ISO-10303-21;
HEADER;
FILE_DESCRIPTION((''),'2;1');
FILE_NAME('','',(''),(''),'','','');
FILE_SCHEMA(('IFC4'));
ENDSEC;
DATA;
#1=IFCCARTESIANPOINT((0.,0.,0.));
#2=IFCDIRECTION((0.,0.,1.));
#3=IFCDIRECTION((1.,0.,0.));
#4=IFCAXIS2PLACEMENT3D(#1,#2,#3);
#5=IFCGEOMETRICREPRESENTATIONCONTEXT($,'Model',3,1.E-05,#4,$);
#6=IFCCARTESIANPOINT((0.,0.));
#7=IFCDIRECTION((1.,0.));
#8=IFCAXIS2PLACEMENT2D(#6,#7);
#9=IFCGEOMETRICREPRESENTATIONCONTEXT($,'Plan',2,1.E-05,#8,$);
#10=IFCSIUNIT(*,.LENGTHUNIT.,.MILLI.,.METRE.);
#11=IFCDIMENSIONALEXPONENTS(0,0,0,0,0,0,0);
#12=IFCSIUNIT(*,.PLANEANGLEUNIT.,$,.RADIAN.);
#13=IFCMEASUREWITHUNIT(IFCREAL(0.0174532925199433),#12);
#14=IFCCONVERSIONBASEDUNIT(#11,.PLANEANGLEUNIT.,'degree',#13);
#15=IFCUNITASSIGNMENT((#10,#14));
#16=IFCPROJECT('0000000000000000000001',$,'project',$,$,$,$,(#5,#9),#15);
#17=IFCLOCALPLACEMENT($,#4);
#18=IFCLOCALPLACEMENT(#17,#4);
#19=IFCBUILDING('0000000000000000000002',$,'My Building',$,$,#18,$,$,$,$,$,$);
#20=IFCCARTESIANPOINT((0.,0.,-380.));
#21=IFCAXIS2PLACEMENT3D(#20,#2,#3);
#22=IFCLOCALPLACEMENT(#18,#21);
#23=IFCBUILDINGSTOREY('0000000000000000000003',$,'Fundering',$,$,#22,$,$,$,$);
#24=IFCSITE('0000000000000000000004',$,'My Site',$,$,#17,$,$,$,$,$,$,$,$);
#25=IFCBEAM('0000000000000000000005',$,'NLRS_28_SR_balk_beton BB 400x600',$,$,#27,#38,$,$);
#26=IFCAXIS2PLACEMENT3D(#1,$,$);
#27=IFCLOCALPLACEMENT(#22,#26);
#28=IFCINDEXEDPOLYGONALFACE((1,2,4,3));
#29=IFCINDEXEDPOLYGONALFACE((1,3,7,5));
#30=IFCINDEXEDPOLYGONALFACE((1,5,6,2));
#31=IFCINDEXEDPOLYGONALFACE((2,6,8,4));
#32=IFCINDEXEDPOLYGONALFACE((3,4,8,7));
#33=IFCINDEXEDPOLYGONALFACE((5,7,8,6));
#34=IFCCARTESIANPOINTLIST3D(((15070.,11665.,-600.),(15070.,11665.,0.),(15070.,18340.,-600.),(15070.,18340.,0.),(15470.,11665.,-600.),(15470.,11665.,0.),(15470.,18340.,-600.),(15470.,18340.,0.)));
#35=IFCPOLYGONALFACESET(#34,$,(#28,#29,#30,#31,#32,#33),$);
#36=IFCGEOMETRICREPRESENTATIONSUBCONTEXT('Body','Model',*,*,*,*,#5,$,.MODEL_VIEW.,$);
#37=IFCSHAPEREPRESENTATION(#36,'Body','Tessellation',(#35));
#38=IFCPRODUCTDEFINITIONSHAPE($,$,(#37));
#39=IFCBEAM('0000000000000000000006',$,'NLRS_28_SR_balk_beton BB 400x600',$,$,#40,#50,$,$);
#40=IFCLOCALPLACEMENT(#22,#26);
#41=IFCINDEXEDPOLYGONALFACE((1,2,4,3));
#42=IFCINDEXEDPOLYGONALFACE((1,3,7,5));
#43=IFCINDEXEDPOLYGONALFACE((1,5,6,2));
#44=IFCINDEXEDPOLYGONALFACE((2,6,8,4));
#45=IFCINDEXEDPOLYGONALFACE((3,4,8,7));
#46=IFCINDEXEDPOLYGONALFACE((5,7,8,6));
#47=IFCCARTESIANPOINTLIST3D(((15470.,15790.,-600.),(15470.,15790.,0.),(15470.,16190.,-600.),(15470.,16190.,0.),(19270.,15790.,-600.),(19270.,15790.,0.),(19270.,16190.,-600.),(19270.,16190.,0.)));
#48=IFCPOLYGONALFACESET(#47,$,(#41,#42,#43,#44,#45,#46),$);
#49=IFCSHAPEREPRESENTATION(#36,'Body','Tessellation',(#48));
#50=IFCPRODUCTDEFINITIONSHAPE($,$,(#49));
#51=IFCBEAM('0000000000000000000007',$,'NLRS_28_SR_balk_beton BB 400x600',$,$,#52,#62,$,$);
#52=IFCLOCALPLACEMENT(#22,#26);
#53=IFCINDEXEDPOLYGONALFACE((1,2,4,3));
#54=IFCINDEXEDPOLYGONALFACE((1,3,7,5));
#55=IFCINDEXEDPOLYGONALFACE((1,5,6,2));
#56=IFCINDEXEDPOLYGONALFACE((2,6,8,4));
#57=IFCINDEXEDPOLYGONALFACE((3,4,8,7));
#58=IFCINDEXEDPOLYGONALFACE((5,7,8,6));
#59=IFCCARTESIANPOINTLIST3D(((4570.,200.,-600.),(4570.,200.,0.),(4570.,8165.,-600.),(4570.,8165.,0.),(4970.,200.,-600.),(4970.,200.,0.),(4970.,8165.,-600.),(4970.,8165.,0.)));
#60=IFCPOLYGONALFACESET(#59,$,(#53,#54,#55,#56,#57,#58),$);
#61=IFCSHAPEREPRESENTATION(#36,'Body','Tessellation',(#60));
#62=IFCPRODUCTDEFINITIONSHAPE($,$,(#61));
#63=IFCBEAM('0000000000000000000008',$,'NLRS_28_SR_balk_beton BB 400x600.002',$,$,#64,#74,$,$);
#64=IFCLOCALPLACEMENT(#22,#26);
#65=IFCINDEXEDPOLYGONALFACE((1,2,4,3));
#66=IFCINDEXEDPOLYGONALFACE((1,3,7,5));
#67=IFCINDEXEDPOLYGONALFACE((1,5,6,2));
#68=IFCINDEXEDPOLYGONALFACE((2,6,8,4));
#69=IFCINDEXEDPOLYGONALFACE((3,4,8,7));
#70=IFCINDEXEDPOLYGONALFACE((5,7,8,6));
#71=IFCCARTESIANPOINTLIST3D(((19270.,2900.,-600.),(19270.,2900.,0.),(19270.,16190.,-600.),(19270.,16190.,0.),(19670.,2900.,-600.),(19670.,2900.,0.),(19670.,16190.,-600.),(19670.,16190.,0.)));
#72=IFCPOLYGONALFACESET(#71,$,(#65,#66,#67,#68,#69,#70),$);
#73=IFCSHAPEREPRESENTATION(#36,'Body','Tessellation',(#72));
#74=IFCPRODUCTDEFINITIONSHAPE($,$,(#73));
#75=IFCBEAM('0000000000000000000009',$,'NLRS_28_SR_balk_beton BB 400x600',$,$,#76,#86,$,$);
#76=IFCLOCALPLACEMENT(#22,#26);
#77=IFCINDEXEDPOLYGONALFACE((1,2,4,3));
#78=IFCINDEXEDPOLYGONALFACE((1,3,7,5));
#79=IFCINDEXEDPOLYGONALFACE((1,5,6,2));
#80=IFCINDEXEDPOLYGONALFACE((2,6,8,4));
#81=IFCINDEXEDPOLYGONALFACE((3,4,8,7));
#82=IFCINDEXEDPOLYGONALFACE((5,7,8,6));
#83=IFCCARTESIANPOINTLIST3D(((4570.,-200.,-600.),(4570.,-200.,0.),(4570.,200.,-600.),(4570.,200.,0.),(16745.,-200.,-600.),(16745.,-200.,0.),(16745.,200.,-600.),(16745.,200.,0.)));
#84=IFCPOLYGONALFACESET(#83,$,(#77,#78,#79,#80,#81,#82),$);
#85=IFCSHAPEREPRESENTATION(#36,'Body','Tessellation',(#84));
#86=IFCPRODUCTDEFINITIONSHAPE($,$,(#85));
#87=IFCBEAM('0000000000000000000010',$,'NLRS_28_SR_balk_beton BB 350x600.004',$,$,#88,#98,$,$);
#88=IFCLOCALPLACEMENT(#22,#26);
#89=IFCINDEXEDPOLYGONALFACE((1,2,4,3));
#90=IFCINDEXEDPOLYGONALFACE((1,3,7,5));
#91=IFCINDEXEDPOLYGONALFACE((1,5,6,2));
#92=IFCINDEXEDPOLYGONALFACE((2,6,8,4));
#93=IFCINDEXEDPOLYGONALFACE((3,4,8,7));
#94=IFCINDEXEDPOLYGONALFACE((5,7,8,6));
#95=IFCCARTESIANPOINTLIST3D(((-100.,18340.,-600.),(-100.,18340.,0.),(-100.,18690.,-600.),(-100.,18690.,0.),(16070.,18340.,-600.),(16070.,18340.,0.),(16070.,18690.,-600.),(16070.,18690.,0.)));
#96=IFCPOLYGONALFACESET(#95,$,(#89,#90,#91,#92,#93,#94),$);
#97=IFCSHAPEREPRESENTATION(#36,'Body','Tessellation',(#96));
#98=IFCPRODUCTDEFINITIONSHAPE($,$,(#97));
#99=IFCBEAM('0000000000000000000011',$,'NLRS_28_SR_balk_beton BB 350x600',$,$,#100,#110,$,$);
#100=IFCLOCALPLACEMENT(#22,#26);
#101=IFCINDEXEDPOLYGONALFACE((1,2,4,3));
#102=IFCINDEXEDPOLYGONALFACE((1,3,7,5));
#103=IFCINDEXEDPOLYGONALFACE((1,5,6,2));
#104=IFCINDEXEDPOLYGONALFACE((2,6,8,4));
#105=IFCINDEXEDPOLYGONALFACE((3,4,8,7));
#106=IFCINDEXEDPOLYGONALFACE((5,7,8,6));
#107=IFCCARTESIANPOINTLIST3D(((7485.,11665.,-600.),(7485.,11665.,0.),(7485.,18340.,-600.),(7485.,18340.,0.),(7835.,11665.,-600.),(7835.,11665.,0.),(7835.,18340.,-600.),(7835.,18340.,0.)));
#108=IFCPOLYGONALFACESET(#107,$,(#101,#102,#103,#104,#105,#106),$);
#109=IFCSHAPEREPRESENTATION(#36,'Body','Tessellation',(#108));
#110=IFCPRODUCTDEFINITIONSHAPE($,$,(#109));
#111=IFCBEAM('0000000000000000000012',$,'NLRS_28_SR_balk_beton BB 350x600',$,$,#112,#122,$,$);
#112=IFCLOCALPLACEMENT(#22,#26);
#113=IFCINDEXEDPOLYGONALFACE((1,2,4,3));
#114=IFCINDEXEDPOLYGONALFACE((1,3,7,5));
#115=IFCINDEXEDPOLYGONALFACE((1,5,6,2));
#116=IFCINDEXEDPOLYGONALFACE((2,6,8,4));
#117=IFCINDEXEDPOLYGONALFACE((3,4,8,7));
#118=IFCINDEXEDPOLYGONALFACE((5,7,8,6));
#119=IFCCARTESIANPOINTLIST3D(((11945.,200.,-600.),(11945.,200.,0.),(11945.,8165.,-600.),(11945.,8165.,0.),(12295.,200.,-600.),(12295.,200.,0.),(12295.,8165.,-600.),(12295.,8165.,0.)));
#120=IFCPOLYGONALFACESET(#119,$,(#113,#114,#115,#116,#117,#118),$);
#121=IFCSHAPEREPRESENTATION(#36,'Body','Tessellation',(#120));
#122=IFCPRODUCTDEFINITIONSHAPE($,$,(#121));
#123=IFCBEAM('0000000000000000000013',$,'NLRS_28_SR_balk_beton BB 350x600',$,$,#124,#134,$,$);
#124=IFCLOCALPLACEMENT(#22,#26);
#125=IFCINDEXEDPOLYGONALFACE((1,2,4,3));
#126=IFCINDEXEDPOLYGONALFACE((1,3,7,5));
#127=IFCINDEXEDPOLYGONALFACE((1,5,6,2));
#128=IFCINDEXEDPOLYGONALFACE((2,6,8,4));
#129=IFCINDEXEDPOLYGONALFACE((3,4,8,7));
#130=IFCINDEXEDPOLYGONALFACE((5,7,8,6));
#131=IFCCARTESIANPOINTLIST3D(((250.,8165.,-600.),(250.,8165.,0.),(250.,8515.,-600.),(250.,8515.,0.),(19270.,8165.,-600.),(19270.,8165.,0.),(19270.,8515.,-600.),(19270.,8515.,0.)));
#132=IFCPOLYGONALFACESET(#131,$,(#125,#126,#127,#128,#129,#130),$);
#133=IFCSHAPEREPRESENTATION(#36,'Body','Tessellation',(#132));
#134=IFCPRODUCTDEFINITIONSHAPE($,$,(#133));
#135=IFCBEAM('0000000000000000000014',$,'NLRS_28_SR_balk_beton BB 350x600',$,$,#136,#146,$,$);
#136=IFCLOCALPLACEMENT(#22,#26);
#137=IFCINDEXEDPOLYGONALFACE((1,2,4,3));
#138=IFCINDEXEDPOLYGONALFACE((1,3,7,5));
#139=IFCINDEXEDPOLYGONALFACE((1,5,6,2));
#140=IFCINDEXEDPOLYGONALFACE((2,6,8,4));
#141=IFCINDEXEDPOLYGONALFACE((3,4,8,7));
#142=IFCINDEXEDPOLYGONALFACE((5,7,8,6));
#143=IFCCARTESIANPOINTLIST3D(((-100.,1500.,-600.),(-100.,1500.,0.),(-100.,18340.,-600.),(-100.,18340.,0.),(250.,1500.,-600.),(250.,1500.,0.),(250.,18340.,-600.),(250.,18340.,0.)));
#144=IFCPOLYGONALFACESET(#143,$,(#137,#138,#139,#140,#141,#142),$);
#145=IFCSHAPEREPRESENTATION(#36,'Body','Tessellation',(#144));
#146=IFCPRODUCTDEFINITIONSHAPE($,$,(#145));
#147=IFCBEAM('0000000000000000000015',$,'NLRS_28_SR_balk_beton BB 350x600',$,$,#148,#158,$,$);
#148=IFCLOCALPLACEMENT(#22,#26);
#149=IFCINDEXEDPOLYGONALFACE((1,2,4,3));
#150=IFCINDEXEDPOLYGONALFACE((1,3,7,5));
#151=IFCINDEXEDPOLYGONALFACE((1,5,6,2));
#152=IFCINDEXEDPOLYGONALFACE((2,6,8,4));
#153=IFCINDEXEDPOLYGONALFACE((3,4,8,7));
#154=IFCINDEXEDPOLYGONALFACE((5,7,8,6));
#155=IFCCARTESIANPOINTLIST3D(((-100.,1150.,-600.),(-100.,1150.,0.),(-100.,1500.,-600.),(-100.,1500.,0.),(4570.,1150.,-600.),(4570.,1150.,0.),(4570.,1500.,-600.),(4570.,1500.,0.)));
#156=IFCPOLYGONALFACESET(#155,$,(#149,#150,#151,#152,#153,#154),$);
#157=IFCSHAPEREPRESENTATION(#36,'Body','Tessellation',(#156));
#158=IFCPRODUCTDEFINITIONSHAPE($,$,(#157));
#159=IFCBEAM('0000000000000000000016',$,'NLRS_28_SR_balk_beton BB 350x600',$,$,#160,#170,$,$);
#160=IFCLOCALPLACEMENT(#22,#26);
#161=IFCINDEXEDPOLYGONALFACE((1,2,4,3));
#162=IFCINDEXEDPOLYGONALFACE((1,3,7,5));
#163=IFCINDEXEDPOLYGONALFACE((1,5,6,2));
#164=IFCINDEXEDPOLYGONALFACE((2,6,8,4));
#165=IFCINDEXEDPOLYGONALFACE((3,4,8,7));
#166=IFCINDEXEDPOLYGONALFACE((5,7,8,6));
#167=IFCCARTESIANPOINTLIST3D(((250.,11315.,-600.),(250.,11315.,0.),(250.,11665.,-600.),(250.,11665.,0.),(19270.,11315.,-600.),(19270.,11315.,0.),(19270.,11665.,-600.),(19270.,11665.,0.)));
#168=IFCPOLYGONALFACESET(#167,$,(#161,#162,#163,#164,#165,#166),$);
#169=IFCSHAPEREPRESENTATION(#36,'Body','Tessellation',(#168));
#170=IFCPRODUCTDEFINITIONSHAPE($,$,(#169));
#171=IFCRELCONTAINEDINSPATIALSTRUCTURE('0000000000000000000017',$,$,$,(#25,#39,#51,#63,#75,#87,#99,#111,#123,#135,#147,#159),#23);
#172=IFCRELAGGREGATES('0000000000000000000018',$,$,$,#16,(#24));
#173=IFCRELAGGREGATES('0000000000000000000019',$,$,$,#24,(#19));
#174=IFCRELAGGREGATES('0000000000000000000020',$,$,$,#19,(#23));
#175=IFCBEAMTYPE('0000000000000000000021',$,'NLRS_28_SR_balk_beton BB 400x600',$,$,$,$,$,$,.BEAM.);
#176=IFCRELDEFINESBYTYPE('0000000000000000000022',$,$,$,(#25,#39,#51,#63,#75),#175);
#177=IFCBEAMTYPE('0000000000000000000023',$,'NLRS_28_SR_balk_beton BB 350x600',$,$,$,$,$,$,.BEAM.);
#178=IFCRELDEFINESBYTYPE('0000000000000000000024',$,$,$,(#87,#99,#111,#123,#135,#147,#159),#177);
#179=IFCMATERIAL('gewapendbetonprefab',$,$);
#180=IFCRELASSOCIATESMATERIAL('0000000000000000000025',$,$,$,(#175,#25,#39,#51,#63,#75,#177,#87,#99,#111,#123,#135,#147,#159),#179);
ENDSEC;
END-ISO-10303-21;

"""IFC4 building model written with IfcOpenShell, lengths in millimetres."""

from ifc_helpers import new_model, entity, si_unit, converted_unit, frame, origin_with_axes, origin_2d_with_axis, place, context, subcontext, project, spatial, rectangle, extrude, material, material_profile, profile_set, profile_usage, type_object, element, save


model = new_model("IFC4")

# Units and contexts
model_context = context("Model", 3, precision=1e-05, world=origin_with_axes())
plan_context = context("Plan", 2, precision=1e-05, world=origin_2d_with_axis())
body_context = subcontext(model_context, "Body", "Model", "MODEL_VIEW")
ifc_project = project(units=[si_unit("LENGTHUNIT", "METRE", prefix="MILLI"), converted_unit("PLANEANGLEUNIT", "degree", entity("IfcReal", 0.0174532925199433), si_unit("PLANEANGLEUNIT", "RADIAN"), dimensions=[0, 0, 0, 0, 0, 0, 0])], contexts=[model_context, plan_context])

# Site, building, storey
site_placement = place(None, origin_with_axes())
site = spatial("IfcSite", under=ifc_project, at=site_placement, Name="My Site")
building_placement = place(site_placement, origin_with_axes())
building = spatial("IfcBuilding", under=site, at=building_placement, Name="My Building")
storey_placement = place(building_placement, frame((0.0, 0.0, -380.0), z_axis=(0.0, 0.0, 1.0), x_axis=(1.0, 0.0, 0.0)))
storey = spatial("IfcBuildingStorey", under=building, at=storey_placement, Name="Fundering")

# Beams
ifc_material = material(Name="gewapendbetonprefab")
ifc_material_profile_1 = material_profile(ifc_material, rectangle(XDim=400.0, YDim=600.0))
ifc_profile_set_1 = profile_set([ifc_material_profile_1], Name="NLRS_28_SR_balk_beton BB 400x600")
ifc_profile_usage_1 = profile_usage(ifc_profile_set_1, cardinal=8)
beam_type_1 = type_object("IfcBeamType", Name="NLRS_28_SR_balk_beton BB 400x600", PredefinedType="BEAM", material=ifc_profile_set_1)
beam_1_placement = place(storey_placement, frame((15270.0, 11665.0, 0.0), z_axis=(0.0, 1.0, 0.0), x_axis=(-1.0, 0.0, 0.0)))
element("IfcBeam", 1, at=beam_1_placement, inside=storey, type_object=beam_type_1, material=ifc_profile_usage_1, Name="NLRS_28_SR_balk_beton BB 400x600", context=body_context, shape_type="SweptSolid", body=[
    extrude(rectangle(XDim=400.0, YDim=600.0), frame((0.0, -300.0, 0.0), z_axis=(0.0, 0.0, 1.0), x_axis=(1.0, 0.0, 0.0)), (0.0, 0.0, 1.0), 6675.0),
])
ifc_profile_usage_2 = profile_usage(ifc_profile_set_1, cardinal=8)
beam_2_placement = place(storey_placement, frame((19270.0, 15990.0, 0.0), z_axis=(-1.0, 0.0, 0.0), x_axis=(0.0, -1.0, 0.0)))
element("IfcBeam", 2, at=beam_2_placement, inside=storey, type_object=beam_type_1, material=ifc_profile_usage_2, Name="NLRS_28_SR_balk_beton BB 400x600", context=body_context, shape_type="SweptSolid", body=[
    extrude(rectangle(XDim=400.0, YDim=600.0), frame((0.0, -300.0, 0.0), z_axis=(0.0, 0.0, 1.0), x_axis=(1.0, 0.0, 0.0)), (0.0, 0.0, 1.0), 3800.0),
])
ifc_profile_usage_3 = profile_usage(ifc_profile_set_1, cardinal=8)
beam_3_placement = place(storey_placement, frame((4770.0, 200.0, 0.0), z_axis=(0.0, 1.0, 0.0), x_axis=(-1.0, 0.0, 0.0)))
element("IfcBeam", 3, at=beam_3_placement, inside=storey, type_object=beam_type_1, material=ifc_profile_usage_3, Name="NLRS_28_SR_balk_beton BB 400x600", context=body_context, shape_type="SweptSolid", body=[
    extrude(rectangle(XDim=400.0, YDim=600.0), frame((0.0, -300.0, 0.0), z_axis=(0.0, 0.0, 1.0), x_axis=(1.0, 0.0, 0.0)), (0.0, 0.0, 1.0), 7965.0),
])
ifc_profile_usage_4 = profile_usage(ifc_profile_set_1, cardinal=8)
beam_4_placement = place(storey_placement, frame((19470.0, 2900.0, 0.0), z_axis=(0.0, 1.0, 0.0), x_axis=(-1.0, 0.0, 0.0)))
element("IfcBeam", 4, at=beam_4_placement, inside=storey, type_object=beam_type_1, material=ifc_profile_usage_4, Name="NLRS_28_SR_balk_beton BB 400x600.002", context=body_context, shape_type="SweptSolid", body=[
    extrude(rectangle(XDim=400.0, YDim=600.0), frame((0.0, -300.0, 0.0), z_axis=(0.0, 0.0, 1.0), x_axis=(1.0, 0.0, 0.0)), (0.0, 0.0, 1.0), 13290.0),
])
ifc_profile_usage_5 = profile_usage(ifc_profile_set_1, cardinal=8)
beam_5_placement = place(storey_placement, frame((4570.0, 0.0, 0.0), z_axis=(1.0, 0.0, 0.0), x_axis=(0.0, 1.0, 0.0)))
element("IfcBeam", 5, at=beam_5_placement, inside=storey, type_object=beam_type_1, material=ifc_profile_usage_5, Name="NLRS_28_SR_balk_beton BB 400x600", context=body_context, shape_type="SweptSolid", body=[
    extrude(rectangle(XDim=400.0, YDim=600.0), frame((0.0, -300.0, 0.0), z_axis=(0.0, 0.0, 1.0), x_axis=(1.0, 0.0, 0.0)), (0.0, 0.0, 1.0), 12175.0),
])
ifc_material_profile_2 = material_profile(ifc_material, rectangle(XDim=350.0, YDim=600.0))
ifc_profile_set_2 = profile_set([ifc_material_profile_2], Name="NLRS_28_SR_balk_beton BB 350x600")
ifc_profile_usage_6 = profile_usage(ifc_profile_set_2, cardinal=8)
beam_type_2 = type_object("IfcBeamType", Name="NLRS_28_SR_balk_beton BB 350x600", PredefinedType="BEAM", material=ifc_profile_set_2)
beam_6_placement = place(storey_placement, frame((-100.0, 18515.0, 0.0), z_axis=(1.0, 0.0, 0.0), x_axis=(0.0, 1.0, 0.0)))
element("IfcBeam", 6, at=beam_6_placement, inside=storey, type_object=beam_type_2, material=ifc_profile_usage_6, Name="NLRS_28_SR_balk_beton BB 350x600.004", context=body_context, shape_type="SweptSolid", body=[
    extrude(rectangle(XDim=350.0, YDim=600.0), frame((0.0, -300.0, 0.0)), (0.0, 0.0, 1.0), 16170.0),
])
ifc_profile_usage_7 = profile_usage(ifc_profile_set_2, cardinal=8)
beam_7_placement = place(storey_placement, frame((7660.0, 11665.0, 0.0), z_axis=(0.0, 1.0, 0.0), x_axis=(-1.0, 0.0, 0.0)))
element("IfcBeam", 7, at=beam_7_placement, inside=storey, type_object=beam_type_2, material=ifc_profile_usage_7, Name="NLRS_28_SR_balk_beton BB 350x600", context=body_context, shape_type="SweptSolid", body=[
    extrude(rectangle(XDim=350.0, YDim=600.0), frame((0.0, -300.0, 0.0), z_axis=(0.0, 0.0, 1.0), x_axis=(1.0, 0.0, 0.0)), (0.0, 0.0, 1.0), 6675.0),
])
ifc_profile_usage_8 = profile_usage(ifc_profile_set_2)
beam_8_placement = place(storey_placement, frame((12120.0, 200.0, -300.0), z_axis=(0.0, 1.0, 0.0), x_axis=(-1.0, 0.0, 0.0)))
element("IfcBeam", 8, at=beam_8_placement, inside=storey, type_object=beam_type_2, material=ifc_profile_usage_8, Name="NLRS_28_SR_balk_beton BB 350x600", context=body_context, shape_type="SweptSolid", body=[
    extrude(rectangle(XDim=350.0, YDim=600.0), origin_with_axes(), (0.0, 0.0, 1.0), 7965.0),
])
ifc_profile_usage_9 = profile_usage(ifc_profile_set_2, cardinal=8)
beam_9_placement = place(storey_placement, frame((19270.0, 8340.0, 0.0), z_axis=(-1.0, 0.0, 0.0), x_axis=(0.0, -1.0, 0.0)))
element("IfcBeam", 9, at=beam_9_placement, inside=storey, type_object=beam_type_2, material=ifc_profile_usage_9, Name="NLRS_28_SR_balk_beton BB 350x600", context=body_context, shape_type="SweptSolid", body=[
    extrude(rectangle(XDim=350.0, YDim=600.0), frame((0.0, -300.0, 0.0), z_axis=(0.0, 0.0, 1.0), x_axis=(1.0, 0.0, 0.0)), (0.0, 0.0, 1.0), 19020.0),
])
ifc_profile_usage_10 = profile_usage(ifc_profile_set_2, cardinal=8)
beam_10_placement = place(storey_placement, frame((75.0, 1500.0, 0.0), z_axis=(0.0, 1.0, 0.0), x_axis=(-1.0, 0.0, 0.0)))
element("IfcBeam", 10, at=beam_10_placement, inside=storey, type_object=beam_type_2, material=ifc_profile_usage_10, Name="NLRS_28_SR_balk_beton BB 350x600", context=body_context, shape_type="SweptSolid", body=[
    extrude(rectangle(XDim=350.0, YDim=600.0), frame((0.0, -300.0, 0.0), z_axis=(0.0, 0.0, 1.0), x_axis=(1.0, 0.0, 0.0)), (0.0, 0.0, 1.0), 16840.0),
])
ifc_profile_usage_11 = profile_usage(ifc_profile_set_2, cardinal=8)
beam_11_placement = place(storey_placement, frame((4570.0, 1325.0, 0.0), z_axis=(-1.0, 0.0, 0.0), x_axis=(0.0, -1.0, 0.0)))
element("IfcBeam", 11, at=beam_11_placement, inside=storey, type_object=beam_type_2, material=ifc_profile_usage_11, Name="NLRS_28_SR_balk_beton BB 350x600", context=body_context, shape_type="SweptSolid", body=[
    extrude(rectangle(XDim=350.0, YDim=600.0), frame((0.0, -300.0, 0.0), z_axis=(0.0, 0.0, 1.0), x_axis=(1.0, 0.0, 0.0)), (0.0, 0.0, 1.0), 4670.0),
])
ifc_profile_usage_12 = profile_usage(ifc_profile_set_2, cardinal=8)
beam_12_placement = place(storey_placement, frame((19270.0, 11490.0, 0.0), z_axis=(-1.0, 0.0, 0.0), x_axis=(0.0, -1.0, 0.0)))
element("IfcBeam", 12, at=beam_12_placement, inside=storey, type_object=beam_type_2, material=ifc_profile_usage_12, Name="NLRS_28_SR_balk_beton BB 350x600", context=body_context, shape_type="SweptSolid", body=[
    extrude(rectangle(XDim=350.0, YDim=600.0), frame((0.0, -300.0, 0.0), z_axis=(0.0, 0.0, 1.0), x_axis=(1.0, 0.0, 0.0)), (0.0, 0.0, 1.0), 19020.0),
])

save(model, "model.ifc")
